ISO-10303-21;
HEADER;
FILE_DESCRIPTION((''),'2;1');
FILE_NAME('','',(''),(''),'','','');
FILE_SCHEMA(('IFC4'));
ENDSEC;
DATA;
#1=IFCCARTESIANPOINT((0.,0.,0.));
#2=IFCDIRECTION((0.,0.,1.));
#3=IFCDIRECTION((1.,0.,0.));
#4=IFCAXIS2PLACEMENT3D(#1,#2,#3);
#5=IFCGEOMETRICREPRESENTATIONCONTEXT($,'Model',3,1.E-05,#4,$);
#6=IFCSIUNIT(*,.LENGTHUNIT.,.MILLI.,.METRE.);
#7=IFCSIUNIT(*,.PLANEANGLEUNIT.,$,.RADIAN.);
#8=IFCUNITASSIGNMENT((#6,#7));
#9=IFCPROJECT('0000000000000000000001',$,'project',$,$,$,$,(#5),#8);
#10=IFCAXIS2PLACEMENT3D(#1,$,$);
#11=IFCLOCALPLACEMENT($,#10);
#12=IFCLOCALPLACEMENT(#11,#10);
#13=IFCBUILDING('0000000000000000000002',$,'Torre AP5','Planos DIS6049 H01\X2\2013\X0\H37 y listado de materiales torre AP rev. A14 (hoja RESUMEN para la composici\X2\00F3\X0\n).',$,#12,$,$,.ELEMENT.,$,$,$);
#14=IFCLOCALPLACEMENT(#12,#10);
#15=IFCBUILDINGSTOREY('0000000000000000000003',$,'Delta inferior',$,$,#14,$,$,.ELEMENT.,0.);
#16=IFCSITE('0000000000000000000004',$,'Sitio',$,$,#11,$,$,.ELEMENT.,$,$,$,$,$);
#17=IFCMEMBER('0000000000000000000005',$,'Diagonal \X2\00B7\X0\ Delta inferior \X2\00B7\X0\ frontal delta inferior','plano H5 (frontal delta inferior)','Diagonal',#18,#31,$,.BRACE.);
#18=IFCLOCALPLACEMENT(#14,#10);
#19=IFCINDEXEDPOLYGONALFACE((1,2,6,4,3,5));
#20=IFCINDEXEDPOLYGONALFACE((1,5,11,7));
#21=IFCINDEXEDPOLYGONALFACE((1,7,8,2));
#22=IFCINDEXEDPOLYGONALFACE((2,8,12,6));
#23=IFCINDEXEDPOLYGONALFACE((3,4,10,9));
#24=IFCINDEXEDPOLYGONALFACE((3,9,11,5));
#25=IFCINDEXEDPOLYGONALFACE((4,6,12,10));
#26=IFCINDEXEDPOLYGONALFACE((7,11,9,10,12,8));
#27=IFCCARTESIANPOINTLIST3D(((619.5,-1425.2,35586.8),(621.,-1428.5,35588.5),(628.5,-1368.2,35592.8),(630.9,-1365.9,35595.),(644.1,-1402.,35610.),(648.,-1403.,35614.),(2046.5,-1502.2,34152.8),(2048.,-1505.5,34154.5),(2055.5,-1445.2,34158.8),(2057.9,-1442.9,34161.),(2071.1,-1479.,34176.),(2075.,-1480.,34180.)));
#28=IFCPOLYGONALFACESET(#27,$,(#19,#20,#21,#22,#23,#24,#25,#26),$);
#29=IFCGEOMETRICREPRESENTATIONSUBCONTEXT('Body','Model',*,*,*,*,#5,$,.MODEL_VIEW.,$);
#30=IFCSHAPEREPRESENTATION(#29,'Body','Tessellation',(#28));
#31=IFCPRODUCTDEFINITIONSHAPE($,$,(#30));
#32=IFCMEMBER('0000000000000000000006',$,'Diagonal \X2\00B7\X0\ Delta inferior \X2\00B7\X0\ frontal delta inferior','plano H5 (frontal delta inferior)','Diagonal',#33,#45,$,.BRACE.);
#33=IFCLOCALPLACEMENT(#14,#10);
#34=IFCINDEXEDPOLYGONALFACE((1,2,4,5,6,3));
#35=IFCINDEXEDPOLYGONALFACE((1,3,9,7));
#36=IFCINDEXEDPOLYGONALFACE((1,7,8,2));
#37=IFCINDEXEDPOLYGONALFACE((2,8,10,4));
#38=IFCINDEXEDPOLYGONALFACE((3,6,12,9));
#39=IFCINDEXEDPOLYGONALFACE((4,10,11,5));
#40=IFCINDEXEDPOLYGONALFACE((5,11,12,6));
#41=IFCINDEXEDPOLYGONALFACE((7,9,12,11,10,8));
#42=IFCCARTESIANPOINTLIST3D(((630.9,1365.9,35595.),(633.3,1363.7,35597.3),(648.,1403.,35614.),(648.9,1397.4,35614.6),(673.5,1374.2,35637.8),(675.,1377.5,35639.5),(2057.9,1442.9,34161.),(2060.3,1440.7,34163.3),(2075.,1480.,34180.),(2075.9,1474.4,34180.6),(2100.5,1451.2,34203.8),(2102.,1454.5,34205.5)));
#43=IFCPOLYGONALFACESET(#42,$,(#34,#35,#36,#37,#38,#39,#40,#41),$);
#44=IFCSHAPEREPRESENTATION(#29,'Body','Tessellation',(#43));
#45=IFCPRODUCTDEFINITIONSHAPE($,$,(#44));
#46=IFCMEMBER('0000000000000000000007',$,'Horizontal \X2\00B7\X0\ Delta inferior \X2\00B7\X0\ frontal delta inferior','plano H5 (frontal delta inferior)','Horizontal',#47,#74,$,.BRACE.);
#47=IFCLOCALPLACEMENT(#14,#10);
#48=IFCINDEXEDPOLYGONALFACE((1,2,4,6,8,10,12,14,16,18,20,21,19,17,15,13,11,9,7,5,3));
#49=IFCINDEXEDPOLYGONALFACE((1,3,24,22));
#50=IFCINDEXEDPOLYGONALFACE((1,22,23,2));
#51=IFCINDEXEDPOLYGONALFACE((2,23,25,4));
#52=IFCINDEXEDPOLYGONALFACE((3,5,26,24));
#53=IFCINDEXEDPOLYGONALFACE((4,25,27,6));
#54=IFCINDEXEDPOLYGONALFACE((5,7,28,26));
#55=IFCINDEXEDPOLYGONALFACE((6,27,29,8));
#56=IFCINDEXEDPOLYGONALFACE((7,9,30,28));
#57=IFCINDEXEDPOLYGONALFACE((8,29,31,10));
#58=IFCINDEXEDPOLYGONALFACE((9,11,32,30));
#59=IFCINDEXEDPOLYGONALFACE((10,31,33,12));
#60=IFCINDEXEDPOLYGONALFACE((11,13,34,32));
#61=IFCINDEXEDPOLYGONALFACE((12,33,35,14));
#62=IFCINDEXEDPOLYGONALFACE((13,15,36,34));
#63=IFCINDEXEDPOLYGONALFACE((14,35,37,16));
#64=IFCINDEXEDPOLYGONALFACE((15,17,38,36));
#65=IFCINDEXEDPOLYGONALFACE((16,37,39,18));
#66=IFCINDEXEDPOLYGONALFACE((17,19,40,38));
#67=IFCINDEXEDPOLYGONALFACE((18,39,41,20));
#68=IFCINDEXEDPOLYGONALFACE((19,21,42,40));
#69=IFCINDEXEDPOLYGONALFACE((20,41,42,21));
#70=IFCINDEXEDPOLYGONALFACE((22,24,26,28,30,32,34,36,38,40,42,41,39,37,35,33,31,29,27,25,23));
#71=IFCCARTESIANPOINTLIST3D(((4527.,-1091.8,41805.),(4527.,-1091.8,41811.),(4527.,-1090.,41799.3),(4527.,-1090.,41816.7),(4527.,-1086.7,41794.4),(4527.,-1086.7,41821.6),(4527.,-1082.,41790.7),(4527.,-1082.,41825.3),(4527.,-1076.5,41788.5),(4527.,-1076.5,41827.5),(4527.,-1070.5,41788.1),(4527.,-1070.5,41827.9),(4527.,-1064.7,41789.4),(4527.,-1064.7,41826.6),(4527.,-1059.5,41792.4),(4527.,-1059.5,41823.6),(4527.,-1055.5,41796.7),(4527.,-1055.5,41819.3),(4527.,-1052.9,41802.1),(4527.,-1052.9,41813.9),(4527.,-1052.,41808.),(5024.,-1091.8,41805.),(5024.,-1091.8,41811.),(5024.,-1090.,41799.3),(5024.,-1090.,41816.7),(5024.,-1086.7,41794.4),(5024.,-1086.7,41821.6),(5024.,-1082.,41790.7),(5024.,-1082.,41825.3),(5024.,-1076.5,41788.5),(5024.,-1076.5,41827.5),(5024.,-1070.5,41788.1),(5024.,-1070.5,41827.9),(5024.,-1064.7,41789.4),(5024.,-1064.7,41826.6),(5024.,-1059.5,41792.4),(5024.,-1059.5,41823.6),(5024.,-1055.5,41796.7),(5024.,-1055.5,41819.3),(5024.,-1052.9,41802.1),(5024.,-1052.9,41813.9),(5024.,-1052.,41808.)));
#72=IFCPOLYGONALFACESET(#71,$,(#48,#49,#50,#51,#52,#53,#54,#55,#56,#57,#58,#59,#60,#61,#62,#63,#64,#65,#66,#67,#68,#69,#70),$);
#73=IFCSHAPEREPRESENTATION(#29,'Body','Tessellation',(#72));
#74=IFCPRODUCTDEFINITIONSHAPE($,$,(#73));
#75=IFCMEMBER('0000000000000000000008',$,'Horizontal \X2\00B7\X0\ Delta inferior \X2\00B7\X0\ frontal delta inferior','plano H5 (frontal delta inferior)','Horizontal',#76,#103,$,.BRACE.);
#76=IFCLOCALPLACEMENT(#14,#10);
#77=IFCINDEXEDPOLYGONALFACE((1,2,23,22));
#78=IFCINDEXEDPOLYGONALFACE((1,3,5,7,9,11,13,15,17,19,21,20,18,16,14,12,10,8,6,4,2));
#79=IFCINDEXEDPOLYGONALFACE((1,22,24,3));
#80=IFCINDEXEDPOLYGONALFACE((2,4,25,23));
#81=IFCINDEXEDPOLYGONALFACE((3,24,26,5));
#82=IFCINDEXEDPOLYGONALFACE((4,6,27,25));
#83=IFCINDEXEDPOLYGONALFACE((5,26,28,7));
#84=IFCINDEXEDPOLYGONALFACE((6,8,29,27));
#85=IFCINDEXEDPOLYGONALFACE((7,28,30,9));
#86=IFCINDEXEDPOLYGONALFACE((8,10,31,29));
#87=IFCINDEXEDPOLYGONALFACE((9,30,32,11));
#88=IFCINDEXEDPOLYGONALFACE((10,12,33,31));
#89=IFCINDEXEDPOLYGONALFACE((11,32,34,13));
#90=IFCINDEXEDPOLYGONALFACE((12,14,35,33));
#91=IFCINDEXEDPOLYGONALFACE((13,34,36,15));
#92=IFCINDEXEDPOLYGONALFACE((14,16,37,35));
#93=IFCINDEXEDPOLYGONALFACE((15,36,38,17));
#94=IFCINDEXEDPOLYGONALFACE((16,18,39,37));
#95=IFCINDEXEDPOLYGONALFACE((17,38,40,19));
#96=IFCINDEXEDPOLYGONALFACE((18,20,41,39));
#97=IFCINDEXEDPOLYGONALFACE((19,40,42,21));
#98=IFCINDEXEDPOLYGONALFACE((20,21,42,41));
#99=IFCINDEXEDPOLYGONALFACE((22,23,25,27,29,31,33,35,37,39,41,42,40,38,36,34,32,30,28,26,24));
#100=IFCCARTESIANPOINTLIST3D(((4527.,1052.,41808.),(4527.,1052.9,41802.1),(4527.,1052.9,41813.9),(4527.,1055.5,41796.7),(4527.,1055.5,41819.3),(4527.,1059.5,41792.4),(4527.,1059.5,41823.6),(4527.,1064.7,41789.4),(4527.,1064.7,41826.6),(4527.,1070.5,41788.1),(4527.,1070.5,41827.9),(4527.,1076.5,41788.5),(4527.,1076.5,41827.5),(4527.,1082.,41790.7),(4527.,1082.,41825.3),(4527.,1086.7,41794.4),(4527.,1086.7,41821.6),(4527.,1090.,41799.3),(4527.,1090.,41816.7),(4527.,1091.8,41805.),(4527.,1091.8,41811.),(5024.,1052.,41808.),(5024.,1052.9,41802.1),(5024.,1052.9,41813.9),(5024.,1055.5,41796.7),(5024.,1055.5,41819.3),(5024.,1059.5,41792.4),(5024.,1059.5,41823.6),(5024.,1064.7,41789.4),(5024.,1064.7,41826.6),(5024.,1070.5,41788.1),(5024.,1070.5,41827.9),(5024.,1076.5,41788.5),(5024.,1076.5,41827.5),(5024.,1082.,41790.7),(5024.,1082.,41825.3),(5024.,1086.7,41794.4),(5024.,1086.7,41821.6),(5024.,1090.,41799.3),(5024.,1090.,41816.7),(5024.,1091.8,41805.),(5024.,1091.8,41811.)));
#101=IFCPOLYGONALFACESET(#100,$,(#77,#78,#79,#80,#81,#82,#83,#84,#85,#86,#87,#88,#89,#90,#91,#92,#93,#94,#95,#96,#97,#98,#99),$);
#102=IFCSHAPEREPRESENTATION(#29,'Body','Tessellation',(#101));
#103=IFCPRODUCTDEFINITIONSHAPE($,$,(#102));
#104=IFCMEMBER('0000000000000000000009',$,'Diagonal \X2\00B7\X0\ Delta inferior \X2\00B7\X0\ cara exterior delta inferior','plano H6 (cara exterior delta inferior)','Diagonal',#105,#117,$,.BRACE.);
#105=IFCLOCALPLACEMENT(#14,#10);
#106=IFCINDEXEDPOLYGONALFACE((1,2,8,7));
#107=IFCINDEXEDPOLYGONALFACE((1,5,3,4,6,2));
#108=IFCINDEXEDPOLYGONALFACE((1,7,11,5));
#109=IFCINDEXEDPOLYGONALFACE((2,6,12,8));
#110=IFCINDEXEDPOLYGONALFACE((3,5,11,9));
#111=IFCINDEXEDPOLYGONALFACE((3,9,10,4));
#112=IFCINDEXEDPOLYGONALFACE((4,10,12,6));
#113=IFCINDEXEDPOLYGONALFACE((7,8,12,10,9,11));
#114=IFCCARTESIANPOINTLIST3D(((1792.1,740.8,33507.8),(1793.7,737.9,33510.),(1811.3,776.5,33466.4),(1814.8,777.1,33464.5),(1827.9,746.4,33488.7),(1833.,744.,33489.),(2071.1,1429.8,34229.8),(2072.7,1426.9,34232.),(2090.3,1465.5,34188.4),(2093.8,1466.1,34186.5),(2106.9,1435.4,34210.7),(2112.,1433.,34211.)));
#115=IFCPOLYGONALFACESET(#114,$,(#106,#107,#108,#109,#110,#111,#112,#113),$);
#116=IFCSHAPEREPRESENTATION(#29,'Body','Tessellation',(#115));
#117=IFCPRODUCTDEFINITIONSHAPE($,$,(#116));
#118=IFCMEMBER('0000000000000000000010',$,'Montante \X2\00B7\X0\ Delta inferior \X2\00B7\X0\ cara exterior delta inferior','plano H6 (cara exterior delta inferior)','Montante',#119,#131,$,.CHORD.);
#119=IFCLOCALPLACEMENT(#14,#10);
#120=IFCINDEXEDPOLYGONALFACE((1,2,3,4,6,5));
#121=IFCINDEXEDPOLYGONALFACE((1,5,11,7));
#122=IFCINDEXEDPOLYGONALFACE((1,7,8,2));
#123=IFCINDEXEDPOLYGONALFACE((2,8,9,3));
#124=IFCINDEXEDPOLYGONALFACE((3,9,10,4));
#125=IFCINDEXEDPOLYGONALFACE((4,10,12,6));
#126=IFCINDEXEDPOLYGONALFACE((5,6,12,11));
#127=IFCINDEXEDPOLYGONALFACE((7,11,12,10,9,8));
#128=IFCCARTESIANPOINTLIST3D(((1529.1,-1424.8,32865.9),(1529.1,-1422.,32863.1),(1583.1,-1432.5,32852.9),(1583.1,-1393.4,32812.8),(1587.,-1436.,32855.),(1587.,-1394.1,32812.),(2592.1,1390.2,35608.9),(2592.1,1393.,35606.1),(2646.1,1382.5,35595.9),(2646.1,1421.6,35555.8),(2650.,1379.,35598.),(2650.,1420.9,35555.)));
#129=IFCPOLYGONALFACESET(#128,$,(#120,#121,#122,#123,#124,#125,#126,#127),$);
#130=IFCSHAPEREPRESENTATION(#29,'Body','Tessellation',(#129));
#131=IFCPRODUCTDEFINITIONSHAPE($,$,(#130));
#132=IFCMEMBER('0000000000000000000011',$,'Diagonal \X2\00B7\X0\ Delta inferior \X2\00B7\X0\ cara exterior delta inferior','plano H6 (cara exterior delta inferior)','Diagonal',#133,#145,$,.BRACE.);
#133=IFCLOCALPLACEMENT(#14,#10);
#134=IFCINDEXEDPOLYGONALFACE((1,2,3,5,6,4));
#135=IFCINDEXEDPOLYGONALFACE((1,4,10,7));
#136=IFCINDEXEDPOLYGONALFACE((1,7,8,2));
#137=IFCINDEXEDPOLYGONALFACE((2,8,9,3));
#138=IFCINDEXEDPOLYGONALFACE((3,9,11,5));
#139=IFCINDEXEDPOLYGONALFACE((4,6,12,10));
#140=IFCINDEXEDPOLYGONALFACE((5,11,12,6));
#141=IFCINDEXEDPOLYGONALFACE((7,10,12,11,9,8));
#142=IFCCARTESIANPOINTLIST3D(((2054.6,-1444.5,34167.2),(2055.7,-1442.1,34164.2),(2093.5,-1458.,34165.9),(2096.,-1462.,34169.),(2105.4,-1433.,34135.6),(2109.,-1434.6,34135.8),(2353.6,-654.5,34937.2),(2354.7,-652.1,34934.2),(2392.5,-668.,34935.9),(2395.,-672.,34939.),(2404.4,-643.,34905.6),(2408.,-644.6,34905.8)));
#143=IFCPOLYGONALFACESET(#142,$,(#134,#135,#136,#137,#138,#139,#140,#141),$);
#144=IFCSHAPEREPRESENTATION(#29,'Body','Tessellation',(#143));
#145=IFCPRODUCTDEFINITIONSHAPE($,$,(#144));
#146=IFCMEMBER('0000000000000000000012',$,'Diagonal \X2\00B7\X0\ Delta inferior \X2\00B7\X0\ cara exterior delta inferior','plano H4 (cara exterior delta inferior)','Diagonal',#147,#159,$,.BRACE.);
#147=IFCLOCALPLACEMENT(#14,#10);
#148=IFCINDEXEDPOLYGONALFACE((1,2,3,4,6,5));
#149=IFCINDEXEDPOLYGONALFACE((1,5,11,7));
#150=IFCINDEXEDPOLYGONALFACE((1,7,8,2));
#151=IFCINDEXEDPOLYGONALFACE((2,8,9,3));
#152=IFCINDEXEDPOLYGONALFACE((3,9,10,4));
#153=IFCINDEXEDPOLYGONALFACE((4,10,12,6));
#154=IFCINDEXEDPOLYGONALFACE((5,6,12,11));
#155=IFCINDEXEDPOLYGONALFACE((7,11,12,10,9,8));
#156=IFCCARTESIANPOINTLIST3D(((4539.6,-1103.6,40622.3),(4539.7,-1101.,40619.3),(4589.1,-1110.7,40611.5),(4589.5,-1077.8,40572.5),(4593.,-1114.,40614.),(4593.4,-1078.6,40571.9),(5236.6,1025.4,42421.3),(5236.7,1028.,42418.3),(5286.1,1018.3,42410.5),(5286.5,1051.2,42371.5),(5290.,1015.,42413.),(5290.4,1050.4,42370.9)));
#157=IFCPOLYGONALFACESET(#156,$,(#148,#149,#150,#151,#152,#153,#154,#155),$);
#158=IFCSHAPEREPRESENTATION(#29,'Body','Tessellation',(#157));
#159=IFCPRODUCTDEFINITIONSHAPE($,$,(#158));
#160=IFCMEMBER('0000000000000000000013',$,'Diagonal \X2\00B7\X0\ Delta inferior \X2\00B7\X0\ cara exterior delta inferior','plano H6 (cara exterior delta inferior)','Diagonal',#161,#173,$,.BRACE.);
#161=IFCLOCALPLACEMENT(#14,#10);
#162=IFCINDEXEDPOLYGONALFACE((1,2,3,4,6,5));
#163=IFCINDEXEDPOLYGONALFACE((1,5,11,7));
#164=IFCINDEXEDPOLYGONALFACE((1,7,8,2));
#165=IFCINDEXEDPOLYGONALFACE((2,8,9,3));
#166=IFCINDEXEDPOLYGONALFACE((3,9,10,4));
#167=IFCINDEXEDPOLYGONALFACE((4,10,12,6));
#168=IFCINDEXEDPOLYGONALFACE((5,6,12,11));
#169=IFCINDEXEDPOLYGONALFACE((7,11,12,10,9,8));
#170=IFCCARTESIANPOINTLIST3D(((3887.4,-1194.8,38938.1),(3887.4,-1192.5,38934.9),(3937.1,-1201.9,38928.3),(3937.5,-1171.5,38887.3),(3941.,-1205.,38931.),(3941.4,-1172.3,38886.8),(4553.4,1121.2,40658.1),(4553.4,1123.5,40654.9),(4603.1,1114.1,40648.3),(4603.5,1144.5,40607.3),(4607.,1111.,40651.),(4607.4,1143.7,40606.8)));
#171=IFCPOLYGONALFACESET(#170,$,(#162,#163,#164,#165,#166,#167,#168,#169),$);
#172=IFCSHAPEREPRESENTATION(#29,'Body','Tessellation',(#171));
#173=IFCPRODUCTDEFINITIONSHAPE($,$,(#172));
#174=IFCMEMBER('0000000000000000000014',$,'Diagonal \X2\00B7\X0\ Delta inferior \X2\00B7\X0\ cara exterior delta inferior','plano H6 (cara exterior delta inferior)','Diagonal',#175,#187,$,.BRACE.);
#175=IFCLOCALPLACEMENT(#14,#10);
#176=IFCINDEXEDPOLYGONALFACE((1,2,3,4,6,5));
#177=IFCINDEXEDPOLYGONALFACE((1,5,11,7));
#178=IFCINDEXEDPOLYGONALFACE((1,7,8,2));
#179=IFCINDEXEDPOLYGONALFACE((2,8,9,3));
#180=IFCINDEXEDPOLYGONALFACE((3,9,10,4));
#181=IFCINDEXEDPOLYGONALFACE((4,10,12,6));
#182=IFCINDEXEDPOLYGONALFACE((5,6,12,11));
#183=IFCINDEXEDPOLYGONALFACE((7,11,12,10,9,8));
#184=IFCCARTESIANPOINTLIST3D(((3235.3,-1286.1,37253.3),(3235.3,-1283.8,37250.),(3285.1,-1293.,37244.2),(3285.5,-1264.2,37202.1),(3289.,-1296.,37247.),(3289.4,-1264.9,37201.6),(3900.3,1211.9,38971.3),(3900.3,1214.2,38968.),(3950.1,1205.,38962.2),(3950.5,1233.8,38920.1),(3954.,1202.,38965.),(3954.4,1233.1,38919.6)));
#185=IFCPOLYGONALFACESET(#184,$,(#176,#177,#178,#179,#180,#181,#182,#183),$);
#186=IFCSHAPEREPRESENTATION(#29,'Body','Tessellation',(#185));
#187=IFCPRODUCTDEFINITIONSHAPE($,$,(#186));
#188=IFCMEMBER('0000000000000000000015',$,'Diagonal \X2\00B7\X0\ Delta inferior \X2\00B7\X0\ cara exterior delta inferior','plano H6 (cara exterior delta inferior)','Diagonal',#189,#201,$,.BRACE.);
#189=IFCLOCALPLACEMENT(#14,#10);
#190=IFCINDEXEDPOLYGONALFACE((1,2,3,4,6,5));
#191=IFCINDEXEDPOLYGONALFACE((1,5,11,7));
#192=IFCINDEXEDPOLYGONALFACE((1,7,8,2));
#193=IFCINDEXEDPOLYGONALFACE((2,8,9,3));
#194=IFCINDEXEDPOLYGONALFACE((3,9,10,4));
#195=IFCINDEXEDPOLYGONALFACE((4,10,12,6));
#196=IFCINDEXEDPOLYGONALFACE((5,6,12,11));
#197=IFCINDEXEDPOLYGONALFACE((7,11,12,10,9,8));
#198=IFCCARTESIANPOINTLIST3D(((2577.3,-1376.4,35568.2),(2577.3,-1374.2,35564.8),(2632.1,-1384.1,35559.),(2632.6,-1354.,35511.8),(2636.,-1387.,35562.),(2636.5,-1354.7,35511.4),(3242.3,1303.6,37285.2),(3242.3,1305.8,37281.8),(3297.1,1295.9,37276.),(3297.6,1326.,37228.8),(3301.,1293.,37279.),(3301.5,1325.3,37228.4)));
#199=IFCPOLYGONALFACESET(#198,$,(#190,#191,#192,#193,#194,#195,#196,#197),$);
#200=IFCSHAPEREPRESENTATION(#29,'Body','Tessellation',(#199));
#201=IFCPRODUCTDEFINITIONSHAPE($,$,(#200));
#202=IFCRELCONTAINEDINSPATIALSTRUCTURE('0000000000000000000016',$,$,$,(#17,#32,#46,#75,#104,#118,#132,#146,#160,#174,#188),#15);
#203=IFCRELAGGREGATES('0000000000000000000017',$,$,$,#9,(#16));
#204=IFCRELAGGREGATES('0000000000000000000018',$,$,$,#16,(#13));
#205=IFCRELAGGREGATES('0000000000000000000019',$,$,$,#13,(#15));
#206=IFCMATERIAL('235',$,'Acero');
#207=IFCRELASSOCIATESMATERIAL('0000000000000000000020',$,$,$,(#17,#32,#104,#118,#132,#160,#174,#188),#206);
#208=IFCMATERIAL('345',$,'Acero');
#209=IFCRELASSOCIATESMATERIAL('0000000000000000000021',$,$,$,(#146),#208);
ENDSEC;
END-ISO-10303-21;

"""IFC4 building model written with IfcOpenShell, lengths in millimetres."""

from ifc_helpers import new_model, si_unit, frame, frame_2d, origin, origin_with_axes, place, context, subcontext, project, spatial, circle, l_section, extrude, material, element, save


model = new_model("IFC4")

# Units and contexts
model_context = context("Model", 3, precision=1e-05, world=origin_with_axes())
body_context = subcontext(model_context, "Body", "Model", "MODEL_VIEW")
ifc_project = project(units=[si_unit("LENGTHUNIT", "METRE", prefix="MILLI"), si_unit("PLANEANGLEUNIT", "RADIAN")], contexts=[model_context])

# Site, building, storey
site_placement = place(None, origin())
site = spatial("IfcSite", under=ifc_project, at=site_placement, Name="Sitio", CompositionType="ELEMENT")
building_placement = place(site_placement, origin())
building = spatial("IfcBuilding", under=site, at=building_placement, Name="Torre AP5", Description="Planos DIS6049 H01–H37 y listado de materiales torre AP rev. A14 (hoja RESUMEN para la composición).", CompositionType="ELEMENT")
storey_placement = place(building_placement, origin())
storey = spatial("IfcBuildingStorey", under=building, at=storey_placement, Name="Delta inferior", CompositionType="ELEMENT", Elevation=0.0)

# Members
ifc_material_1 = material(Name="235", Category="Acero")
for number, where, z_axis, x_axis, name in (
    (1, (2075.0, -1480.0, 34180.0), (-0.704864, 0.038034, 0.708322), (-0.379432, 0.82348, -0.421797), "Diagonal · Delta inferior · frontal delta inferior"),
    (2, (2075.0, 1480.0, 34180.0), (-0.704864, -0.038034, 0.708322), (-0.379432, -0.82348, -0.421797), "Diagonal · Delta inferior · frontal delta inferior"),
):
    element("IfcMember", number, at=place(storey_placement, frame(where, z_axis=z_axis, x_axis=x_axis)), inside=storey, material=ifc_material_1, Name=name, Description="plano H5 (frontal delta inferior)", ObjectType="Diagonal", PredefinedType="BRACE", context=body_context, shape_type="SweptSolid", body=[
        extrude(l_section(Depth=45.0, Width=45.0, Thickness=4.0, at=frame_2d((22.5, 22.5))), None, (0.0, 0.0, 1.0), 2024.5),
    ])
for number, where, z_axis, x_axis, name in (
    (3, (5024.0, -1072.0, 41808.0), (-1.0, 0.0, 0.0), (0.0, 1.0, 0.0), "Horizontal · Delta inferior · frontal delta inferior"),
    (4, (5024.0, 1072.0, 41808.0), (-1.0, 0.0, 0.0), (0.0, -1.0, 0.0), "Horizontal · Delta inferior · frontal delta inferior"),
):
    element("IfcMember", number, at=place(storey_placement, frame(where, z_axis=z_axis, x_axis=x_axis)), inside=storey, Name=name, Description="plano H5 (frontal delta inferior)", ObjectType="Horizontal", PredefinedType="BRACE", context=body_context, shape_type="SweptSolid", body=[
        extrude(circle(Radius=20.0), None, (0.0, 0.0, 1.0), 497.0),
    ])
member_1_placement = place(storey_placement, frame((2112.0, 1433.0, 34211.0), z_axis=(-0.269236, -0.664888, -0.696733), x_axis=(-0.873631, -0.135855, 0.46724)))
element("IfcMember", 5, at=member_1_placement, inside=storey, material=ifc_material_1, Name="Diagonal · Delta inferior · cara exterior delta inferior", Description="plano H6 (cara exterior delta inferior)", ObjectType="Diagonal", PredefinedType="BRACE", context=body_context, shape_type="SweptSolid", body=[
    extrude(l_section(Depth=45.0, Width=45.0, Thickness=4.0, at=frame_2d((22.5, 22.5))), None, (0.0, 0.0, 1.0), 1036.3),
])
member_2_placement = place(storey_placement, frame((2650.0, 1379.0, 35598.0), z_axis=(-0.261074, -0.691368, -0.673685), x_axis=(-0.965319, 0.186983, 0.182201)))
element("IfcMember", 6, at=member_2_placement, inside=storey, material=ifc_material_1, Name="Montante · Delta inferior · cara exterior delta inferior", Description="plano H6 (cara exterior delta inferior)", ObjectType="Montante", PredefinedType="CHORD", context=body_context, shape_type="SweptSolid", body=[
    extrude(l_section(Depth=60.0, Width=60.0, Thickness=4.0, at=frame_2d((30.0, 30.0))), None, (0.0, 0.0, 1.0), 4071.6),
])
member_3_placement = place(storey_placement, frame((2395.0, -672.0, 34939.0), z_axis=(-0.261597, -0.691176, -0.673678), x_axis=(-0.920687, 0.38817, -0.040739)))
element("IfcMember", 7, at=member_3_placement, inside=storey, material=ifc_material_1, Name="Diagonal · Delta inferior · cara exterior delta inferior", Description="plano H6 (cara exterior delta inferior)", ObjectType="Diagonal", PredefinedType="BRACE", context=body_context, shape_type="SweptSolid", body=[
    extrude(l_section(Depth=45.0, Width=45.0, Thickness=4.0, at=frame_2d((22.5, 22.5))), None, (0.0, 0.0, 1.0), 1143.0),
])
ifc_material_2 = material(Name="345", Category="Acero")
member_4_placement = place(storey_placement, frame((5290.0, 1015.0, 42413.0), z_axis=(-0.242593, -0.741005, -0.626147), x_axis=(-0.970107, 0.189587, 0.151492)))
element("IfcMember", 8, at=member_4_placement, inside=storey, material=ifc_material_2, Name="Diagonal · Delta inferior · cara exterior delta inferior", Description="plano H4 (cara exterior delta inferior)", ObjectType="Diagonal", PredefinedType="BRACE", context=body_context, shape_type="SweptSolid", body=[
    extrude(l_section(Depth=55.0, Width=55.0, Thickness=4.0, at=frame_2d((27.5, 27.5))), None, (0.0, 0.0, 1.0), 2873.1),
])
member_5_placement = place(storey_placement, frame((4607.0, 1111.0, 40651.0), z_axis=(-0.224946, -0.782244, -0.580941), x_axis=(-0.974349, 0.184591, 0.128724)))
element("IfcMember", 9, at=member_5_placement, inside=storey, material=ifc_material_1, Name="Diagonal · Delta inferior · cara exterior delta inferior", Description="plano H6 (cara exterior delta inferior)", ObjectType="Diagonal", PredefinedType="BRACE", context=body_context, shape_type="SweptSolid", body=[
    extrude(l_section(Depth=55.0, Width=55.0, Thickness=4.0, at=frame_2d((27.5, 27.5))), None, (0.0, 0.0, 1.0), 2960.7),
])
member_6_placement = place(storey_placement, frame((3954.0, 1202.0, 38965.0), z_axis=(-0.214252, -0.804812, -0.55351), x_axis=(-0.976751, 0.180783, 0.115217)))
element("IfcMember", 10, at=member_6_placement, inside=storey, material=ifc_material_1, Name="Diagonal · Delta inferior · cara exterior delta inferior", Description="plano H6 (cara exterior delta inferior)", ObjectType="Diagonal", PredefinedType="BRACE", context=body_context, shape_type="SweptSolid", body=[
    extrude(l_section(Depth=55.0, Width=55.0, Thickness=4.0, at=frame_2d((27.5, 27.5))), None, (0.0, 0.0, 1.0), 3103.8),
])
member_7_placement = place(storey_placement, frame((3301.0, 1293.0, 37279.0), z_axis=(-0.204517, -0.824217, -0.528052), x_axis=(-0.978826, 0.176893, 0.102997)))
element("IfcMember", 11, at=member_7_placement, inside=storey, material=ifc_material_1, Name="Diagonal · Delta inferior · cara exterior delta inferior", Description="plano H6 (cara exterior delta inferior)", ObjectType="Diagonal", PredefinedType="BRACE", context=body_context, shape_type="SweptSolid", body=[
    extrude(l_section(Depth=60.0, Width=60.0, Thickness=4.0, at=frame_2d((30.0, 30.0))), None, (0.0, 0.0, 1.0), 3251.6),
])

save(model, "model.ifc")
